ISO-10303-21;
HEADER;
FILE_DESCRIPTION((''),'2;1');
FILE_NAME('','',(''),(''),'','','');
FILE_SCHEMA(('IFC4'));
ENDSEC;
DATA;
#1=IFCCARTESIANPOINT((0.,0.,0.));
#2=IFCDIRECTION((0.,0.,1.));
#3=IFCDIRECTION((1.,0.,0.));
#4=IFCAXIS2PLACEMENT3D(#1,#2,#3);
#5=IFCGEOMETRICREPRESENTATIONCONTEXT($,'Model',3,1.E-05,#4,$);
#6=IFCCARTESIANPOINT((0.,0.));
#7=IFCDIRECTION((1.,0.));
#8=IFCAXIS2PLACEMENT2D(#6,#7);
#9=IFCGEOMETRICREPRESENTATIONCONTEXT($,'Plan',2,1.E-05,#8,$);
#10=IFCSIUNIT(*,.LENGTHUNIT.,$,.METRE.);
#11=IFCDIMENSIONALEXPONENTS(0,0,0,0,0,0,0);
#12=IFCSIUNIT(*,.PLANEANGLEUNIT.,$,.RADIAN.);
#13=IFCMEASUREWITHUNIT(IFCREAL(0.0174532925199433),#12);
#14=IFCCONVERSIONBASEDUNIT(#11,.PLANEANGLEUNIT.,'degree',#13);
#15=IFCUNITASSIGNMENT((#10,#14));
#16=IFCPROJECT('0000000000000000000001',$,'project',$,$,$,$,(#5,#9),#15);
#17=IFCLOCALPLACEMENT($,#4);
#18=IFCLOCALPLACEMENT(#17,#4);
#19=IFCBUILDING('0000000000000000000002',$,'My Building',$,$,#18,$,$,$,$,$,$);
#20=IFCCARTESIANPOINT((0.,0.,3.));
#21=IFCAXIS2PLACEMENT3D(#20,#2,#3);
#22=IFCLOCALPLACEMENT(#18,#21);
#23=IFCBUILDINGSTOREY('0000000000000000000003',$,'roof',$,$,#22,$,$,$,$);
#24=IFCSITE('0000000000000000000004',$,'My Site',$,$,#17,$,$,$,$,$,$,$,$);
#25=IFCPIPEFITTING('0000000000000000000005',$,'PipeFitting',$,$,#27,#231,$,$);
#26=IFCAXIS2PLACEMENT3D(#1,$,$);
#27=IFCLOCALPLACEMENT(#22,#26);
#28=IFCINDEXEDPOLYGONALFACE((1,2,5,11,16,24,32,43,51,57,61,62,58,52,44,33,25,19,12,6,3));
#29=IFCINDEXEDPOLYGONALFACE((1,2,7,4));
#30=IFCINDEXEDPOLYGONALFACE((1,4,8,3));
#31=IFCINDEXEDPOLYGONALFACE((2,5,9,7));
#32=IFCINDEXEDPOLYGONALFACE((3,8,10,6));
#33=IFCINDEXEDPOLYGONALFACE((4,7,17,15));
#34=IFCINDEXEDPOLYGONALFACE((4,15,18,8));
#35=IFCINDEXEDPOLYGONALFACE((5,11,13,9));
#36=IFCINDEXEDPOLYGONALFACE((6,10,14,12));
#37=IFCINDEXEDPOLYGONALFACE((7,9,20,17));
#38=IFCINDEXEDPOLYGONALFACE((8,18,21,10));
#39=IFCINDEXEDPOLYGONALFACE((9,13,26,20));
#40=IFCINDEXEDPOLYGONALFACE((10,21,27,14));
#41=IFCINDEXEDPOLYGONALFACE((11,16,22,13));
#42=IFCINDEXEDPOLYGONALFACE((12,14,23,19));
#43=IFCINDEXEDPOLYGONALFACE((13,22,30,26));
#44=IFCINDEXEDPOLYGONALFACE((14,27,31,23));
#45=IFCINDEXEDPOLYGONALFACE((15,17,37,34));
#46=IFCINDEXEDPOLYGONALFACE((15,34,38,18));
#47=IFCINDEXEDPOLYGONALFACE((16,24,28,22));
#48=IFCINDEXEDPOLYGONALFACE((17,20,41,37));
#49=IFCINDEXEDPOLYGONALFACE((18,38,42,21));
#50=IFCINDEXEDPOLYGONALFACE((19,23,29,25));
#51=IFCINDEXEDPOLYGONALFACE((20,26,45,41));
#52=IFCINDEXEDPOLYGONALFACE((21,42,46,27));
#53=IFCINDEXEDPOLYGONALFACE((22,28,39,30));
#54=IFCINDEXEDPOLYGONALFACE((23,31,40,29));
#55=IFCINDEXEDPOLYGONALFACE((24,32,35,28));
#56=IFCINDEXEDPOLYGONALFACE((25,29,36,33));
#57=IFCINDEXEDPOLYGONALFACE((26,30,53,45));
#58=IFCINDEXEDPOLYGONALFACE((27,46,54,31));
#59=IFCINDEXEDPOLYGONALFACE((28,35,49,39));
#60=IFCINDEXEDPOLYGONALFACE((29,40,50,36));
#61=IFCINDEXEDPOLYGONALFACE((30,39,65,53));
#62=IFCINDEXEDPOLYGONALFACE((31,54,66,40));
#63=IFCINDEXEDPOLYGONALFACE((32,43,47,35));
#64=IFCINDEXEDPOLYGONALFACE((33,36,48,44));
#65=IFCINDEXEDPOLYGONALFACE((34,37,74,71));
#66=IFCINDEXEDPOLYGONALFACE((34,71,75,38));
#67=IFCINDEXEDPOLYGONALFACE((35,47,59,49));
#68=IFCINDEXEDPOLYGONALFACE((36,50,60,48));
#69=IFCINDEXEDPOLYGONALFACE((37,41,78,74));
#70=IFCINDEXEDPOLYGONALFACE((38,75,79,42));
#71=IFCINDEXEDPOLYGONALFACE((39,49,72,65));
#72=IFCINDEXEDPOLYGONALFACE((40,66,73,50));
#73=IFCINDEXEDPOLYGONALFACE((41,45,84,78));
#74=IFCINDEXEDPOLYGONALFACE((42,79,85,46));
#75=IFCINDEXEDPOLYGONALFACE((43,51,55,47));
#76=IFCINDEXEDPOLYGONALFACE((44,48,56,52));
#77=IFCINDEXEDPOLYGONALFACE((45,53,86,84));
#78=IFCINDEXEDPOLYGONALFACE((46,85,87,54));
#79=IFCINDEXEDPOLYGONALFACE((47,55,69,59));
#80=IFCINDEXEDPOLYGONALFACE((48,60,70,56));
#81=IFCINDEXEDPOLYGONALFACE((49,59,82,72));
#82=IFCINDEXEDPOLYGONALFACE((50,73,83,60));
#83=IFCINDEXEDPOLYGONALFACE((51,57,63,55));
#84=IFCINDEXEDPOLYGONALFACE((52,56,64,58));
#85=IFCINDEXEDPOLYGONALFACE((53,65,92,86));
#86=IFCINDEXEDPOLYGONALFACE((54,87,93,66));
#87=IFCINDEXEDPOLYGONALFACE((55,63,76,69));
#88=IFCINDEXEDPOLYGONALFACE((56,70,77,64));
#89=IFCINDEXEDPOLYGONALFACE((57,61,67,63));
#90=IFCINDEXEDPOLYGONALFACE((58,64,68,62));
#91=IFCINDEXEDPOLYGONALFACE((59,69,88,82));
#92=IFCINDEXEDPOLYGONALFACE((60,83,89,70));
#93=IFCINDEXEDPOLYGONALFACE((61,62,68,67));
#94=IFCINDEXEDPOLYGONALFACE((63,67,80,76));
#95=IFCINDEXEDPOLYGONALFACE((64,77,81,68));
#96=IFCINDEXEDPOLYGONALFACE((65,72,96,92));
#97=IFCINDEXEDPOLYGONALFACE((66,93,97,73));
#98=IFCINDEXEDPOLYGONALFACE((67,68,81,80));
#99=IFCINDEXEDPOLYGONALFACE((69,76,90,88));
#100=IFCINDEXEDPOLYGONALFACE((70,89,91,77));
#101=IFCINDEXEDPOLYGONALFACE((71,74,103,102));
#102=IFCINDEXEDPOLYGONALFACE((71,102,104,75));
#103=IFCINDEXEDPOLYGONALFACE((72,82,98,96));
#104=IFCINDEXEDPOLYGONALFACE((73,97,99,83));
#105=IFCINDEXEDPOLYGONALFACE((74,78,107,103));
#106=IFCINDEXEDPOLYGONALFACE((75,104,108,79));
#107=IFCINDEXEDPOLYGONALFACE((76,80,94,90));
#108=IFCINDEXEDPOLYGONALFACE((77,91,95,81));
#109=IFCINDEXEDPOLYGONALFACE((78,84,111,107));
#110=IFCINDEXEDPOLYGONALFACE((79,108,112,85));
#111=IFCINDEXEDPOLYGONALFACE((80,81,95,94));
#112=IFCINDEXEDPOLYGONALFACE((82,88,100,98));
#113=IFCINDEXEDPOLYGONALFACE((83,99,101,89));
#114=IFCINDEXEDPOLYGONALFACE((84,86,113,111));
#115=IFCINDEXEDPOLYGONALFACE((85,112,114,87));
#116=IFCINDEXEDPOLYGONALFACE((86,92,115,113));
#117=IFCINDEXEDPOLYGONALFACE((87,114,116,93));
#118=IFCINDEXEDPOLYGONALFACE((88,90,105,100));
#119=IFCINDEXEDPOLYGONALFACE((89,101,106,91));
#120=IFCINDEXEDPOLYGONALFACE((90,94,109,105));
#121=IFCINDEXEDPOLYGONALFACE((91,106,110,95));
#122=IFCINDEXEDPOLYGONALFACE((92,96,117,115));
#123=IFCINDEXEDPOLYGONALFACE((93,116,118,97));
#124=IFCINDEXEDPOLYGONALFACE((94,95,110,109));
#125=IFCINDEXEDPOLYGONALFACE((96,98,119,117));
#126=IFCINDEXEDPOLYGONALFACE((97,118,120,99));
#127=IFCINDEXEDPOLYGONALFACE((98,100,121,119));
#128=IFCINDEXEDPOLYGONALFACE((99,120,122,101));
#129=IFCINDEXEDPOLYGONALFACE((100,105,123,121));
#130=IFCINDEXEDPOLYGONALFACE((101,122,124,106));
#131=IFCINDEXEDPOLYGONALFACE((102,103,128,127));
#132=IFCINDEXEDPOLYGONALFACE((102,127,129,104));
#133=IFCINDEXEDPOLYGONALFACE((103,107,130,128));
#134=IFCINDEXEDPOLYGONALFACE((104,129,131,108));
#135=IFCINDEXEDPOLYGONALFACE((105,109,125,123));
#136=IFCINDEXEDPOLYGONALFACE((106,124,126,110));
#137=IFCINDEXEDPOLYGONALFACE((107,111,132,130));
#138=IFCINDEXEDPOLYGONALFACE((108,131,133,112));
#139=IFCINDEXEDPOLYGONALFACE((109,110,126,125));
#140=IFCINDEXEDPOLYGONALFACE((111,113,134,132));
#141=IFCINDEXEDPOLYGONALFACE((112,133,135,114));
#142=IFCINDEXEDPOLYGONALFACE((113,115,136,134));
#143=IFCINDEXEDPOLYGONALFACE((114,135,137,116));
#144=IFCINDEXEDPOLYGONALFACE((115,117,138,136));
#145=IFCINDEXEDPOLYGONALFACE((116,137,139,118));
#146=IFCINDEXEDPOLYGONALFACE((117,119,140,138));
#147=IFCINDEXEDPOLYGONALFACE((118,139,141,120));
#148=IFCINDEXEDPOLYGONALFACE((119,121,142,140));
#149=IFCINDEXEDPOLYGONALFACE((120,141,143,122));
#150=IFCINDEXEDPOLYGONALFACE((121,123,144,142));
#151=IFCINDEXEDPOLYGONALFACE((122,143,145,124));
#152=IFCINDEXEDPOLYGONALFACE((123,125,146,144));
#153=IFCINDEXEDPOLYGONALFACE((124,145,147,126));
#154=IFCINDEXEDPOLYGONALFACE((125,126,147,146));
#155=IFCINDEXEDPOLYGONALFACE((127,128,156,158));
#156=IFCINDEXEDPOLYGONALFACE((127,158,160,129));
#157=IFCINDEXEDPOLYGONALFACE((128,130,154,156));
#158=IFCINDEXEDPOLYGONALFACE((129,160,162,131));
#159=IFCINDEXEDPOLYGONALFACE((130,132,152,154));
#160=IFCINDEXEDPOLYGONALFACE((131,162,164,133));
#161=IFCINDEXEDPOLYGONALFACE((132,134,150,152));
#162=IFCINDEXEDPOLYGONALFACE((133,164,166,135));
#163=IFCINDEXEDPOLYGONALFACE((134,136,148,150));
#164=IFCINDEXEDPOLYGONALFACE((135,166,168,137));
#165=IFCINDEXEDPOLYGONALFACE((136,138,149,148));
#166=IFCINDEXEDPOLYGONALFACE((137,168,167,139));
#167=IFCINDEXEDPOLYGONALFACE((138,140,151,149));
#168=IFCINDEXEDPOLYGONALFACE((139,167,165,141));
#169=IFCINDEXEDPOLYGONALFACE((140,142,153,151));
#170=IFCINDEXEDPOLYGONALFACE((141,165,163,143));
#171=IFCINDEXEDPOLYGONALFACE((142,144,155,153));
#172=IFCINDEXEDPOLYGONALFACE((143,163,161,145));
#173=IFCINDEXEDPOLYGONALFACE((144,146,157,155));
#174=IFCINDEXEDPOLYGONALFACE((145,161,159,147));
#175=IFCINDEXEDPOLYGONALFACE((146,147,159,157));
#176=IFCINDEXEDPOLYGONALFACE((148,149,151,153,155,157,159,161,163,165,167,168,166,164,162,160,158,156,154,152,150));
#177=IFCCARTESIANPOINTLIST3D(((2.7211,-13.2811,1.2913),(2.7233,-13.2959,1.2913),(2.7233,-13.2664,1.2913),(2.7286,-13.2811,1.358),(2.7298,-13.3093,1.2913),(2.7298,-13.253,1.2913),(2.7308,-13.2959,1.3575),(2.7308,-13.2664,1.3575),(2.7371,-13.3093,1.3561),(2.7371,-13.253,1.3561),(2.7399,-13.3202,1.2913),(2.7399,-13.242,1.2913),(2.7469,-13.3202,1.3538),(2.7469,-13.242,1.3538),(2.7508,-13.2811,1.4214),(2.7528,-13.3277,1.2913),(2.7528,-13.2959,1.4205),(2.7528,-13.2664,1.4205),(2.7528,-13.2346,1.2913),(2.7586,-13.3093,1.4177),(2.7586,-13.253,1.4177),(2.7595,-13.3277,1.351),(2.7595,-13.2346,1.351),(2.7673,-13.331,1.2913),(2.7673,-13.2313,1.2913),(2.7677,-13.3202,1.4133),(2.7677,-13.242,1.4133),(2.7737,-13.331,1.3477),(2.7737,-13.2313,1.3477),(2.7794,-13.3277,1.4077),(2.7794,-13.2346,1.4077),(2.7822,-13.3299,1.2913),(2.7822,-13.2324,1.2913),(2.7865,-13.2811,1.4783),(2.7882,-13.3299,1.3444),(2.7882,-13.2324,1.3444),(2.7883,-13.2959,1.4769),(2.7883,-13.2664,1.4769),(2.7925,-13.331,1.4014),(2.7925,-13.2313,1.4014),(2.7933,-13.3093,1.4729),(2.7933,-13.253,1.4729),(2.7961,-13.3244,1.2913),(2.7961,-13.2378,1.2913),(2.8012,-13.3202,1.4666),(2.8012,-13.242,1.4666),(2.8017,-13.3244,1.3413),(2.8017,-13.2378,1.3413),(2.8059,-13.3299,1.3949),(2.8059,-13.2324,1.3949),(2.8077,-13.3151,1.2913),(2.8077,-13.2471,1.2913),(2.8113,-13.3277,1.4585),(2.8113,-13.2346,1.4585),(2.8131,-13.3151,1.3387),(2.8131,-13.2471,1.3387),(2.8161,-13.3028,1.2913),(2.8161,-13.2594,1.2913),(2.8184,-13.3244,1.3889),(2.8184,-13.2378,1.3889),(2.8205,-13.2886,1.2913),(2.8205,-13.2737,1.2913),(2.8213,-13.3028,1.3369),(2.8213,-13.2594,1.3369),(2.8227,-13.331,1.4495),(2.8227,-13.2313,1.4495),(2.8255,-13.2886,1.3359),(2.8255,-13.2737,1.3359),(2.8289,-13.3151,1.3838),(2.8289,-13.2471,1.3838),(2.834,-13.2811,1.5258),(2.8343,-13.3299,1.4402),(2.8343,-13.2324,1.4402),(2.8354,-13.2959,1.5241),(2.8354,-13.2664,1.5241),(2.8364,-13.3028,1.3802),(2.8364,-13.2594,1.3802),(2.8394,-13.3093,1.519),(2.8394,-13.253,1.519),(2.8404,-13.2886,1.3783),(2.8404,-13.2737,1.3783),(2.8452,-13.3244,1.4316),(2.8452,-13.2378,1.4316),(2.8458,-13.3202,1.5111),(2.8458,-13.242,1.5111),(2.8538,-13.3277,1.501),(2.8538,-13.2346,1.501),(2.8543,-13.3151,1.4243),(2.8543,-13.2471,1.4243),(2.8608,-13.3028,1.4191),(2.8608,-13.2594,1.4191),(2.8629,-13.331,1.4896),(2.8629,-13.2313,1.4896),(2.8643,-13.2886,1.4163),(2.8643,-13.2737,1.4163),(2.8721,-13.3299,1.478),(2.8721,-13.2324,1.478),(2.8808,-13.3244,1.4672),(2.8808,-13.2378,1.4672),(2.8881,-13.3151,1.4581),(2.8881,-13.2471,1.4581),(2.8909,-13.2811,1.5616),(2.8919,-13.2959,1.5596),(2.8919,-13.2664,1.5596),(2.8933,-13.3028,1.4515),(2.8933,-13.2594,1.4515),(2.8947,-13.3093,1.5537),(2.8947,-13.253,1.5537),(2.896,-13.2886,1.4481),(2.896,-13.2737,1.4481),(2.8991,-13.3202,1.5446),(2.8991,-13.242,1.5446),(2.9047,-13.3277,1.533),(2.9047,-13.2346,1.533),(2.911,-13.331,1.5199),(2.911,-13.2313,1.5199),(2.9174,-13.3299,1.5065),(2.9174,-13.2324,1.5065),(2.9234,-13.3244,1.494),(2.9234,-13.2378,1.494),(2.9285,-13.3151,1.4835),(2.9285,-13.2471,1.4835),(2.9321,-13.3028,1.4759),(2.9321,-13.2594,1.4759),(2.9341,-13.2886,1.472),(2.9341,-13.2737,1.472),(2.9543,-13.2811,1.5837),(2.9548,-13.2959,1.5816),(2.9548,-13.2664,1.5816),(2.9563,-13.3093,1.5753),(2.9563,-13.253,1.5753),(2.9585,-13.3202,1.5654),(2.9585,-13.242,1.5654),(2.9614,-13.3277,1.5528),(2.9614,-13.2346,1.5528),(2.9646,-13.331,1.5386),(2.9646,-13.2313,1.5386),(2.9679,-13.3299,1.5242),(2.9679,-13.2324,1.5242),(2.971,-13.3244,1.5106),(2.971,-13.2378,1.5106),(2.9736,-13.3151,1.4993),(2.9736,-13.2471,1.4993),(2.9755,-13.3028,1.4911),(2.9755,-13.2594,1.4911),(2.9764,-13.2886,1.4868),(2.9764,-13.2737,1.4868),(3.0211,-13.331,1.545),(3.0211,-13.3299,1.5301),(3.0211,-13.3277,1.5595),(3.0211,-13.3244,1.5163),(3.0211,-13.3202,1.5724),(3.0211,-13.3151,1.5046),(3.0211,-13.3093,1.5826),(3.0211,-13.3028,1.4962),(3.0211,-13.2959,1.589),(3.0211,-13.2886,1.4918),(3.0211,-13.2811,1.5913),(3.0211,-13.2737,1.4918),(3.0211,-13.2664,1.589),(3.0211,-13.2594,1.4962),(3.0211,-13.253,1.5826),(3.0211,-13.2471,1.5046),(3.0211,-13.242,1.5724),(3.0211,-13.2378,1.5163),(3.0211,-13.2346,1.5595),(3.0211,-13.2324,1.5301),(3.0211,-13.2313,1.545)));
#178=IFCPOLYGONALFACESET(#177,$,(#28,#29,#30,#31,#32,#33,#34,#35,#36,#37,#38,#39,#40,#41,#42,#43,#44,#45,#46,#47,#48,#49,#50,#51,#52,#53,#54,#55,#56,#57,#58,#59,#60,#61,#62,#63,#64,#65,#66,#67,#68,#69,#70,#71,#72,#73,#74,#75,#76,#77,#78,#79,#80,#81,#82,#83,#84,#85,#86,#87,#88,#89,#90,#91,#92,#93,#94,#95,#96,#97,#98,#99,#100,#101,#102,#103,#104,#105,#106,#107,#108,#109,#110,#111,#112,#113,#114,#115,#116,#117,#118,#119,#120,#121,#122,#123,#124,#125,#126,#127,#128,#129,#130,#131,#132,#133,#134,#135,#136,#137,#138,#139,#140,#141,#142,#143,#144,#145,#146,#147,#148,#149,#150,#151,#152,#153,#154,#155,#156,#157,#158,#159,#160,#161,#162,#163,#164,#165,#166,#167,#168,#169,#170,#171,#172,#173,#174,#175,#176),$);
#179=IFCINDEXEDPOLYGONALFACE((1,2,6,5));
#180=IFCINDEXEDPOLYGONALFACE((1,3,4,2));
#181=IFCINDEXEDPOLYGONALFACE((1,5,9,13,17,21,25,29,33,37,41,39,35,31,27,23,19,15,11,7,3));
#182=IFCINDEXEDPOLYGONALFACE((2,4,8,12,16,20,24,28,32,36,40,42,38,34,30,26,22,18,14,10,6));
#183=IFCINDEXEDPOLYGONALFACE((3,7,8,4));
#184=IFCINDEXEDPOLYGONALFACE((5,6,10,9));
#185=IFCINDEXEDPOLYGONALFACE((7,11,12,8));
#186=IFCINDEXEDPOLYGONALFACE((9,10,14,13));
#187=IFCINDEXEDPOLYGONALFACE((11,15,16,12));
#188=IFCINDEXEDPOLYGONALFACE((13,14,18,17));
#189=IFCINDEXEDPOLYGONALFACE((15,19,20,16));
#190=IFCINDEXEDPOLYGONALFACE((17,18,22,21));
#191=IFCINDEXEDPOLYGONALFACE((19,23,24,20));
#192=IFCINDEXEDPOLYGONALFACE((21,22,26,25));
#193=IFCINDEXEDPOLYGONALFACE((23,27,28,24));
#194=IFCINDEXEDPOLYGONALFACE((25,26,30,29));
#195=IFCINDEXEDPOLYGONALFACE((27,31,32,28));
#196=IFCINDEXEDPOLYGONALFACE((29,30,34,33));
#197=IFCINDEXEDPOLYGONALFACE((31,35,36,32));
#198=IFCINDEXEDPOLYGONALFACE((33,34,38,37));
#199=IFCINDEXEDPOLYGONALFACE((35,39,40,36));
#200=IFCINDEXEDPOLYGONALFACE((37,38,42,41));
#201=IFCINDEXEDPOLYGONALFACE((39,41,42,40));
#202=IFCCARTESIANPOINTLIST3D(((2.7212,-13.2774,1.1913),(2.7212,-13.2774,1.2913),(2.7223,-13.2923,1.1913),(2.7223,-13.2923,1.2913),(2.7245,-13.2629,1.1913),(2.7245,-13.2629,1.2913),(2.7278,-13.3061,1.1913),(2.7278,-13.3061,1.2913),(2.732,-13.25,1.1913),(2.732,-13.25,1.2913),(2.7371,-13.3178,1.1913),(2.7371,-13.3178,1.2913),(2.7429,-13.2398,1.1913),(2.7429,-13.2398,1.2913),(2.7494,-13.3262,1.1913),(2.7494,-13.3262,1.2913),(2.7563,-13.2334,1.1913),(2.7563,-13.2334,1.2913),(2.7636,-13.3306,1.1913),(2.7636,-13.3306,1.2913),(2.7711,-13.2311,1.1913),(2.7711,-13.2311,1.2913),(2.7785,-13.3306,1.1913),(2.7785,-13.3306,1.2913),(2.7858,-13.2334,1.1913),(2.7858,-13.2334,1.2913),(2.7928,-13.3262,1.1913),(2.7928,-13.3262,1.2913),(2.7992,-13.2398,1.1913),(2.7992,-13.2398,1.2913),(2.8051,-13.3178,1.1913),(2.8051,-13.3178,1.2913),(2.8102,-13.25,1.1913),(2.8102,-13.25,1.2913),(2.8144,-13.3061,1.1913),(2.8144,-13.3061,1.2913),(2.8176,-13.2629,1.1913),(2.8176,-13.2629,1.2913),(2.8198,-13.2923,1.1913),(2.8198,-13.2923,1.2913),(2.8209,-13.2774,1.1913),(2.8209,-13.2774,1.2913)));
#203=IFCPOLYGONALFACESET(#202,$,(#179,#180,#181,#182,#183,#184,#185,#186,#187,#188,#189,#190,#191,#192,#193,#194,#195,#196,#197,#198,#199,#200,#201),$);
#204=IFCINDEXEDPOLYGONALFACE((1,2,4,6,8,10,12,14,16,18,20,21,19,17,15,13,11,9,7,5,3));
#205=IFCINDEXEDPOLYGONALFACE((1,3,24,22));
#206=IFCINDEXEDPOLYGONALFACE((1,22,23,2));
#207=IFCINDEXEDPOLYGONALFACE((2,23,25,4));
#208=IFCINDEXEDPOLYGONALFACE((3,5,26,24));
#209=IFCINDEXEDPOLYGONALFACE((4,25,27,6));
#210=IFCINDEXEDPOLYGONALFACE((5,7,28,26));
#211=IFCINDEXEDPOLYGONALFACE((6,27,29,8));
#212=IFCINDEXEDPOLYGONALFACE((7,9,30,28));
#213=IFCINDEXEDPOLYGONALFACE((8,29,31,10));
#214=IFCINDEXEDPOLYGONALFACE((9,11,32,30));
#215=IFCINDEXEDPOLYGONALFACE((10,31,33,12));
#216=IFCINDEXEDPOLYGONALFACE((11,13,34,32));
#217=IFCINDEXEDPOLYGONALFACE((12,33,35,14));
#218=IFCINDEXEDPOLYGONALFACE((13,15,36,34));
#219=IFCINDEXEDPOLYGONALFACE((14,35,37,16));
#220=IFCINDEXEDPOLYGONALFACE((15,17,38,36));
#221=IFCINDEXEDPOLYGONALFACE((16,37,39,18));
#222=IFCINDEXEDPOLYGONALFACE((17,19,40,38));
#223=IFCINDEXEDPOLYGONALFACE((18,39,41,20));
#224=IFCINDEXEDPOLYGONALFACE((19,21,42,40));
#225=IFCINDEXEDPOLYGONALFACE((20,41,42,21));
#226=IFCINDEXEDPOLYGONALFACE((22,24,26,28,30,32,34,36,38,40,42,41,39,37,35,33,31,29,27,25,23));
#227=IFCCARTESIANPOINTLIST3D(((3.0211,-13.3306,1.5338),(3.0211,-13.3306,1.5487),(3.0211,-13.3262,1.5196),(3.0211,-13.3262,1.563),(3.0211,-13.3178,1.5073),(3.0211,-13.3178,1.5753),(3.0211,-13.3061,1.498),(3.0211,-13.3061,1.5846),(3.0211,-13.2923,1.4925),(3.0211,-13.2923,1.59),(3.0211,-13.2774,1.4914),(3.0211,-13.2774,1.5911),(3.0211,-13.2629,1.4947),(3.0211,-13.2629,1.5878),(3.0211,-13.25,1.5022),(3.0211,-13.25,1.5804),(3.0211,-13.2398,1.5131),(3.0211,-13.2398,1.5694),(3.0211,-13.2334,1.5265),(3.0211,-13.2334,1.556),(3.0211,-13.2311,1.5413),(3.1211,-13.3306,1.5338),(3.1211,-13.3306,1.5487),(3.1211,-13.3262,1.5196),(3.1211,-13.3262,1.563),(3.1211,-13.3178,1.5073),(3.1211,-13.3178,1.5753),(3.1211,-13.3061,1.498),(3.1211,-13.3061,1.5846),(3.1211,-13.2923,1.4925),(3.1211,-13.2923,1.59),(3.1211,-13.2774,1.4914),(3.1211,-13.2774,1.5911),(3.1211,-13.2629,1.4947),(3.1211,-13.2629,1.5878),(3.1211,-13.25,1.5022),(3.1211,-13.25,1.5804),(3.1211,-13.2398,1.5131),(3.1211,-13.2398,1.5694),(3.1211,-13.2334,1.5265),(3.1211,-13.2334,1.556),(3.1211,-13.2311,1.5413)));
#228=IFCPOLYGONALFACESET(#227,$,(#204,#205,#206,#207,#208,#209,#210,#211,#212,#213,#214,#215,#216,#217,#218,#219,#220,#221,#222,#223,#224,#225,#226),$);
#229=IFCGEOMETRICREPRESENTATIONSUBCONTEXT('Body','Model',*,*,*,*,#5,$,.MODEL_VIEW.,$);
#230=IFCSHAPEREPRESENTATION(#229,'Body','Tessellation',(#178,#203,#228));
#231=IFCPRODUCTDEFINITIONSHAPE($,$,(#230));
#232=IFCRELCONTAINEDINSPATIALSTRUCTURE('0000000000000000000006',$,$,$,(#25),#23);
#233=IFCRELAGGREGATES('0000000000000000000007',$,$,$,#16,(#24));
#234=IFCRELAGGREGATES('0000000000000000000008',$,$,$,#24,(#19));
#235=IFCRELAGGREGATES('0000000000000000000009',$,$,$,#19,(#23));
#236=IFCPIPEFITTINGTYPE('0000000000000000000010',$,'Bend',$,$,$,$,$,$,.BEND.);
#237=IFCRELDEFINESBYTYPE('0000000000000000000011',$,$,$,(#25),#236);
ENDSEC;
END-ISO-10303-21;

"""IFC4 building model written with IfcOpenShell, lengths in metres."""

from ifc_helpers import new_model, entity, si_unit, converted_unit, frame, origin_with_axes, origin_2d_with_axis, place, context, subcontext, project, spatial, circle, extrude, source, transform, mapped, type_object, type_shapes, element, save


model = new_model("IFC4")

# Units and contexts
model_context = context("Model", 3, precision=1e-05, world=origin_with_axes())
plan_context = context("Plan", 2, precision=1e-05, world=origin_2d_with_axis())
body_context_1 = subcontext(model_context, "Body", "Model", "MODEL_VIEW")
ifc_project = project(units=[si_unit("LENGTHUNIT", "METRE"), converted_unit("PLANEANGLEUNIT", "degree", entity("IfcReal", 0.0174532925199433), si_unit("PLANEANGLEUNIT", "RADIAN"), dimensions=[0, 0, 0, 0, 0, 0, 0])], contexts=[model_context, plan_context])

# Site, building, storey
site_placement = place(None, origin_with_axes())
site = spatial("IfcSite", under=ifc_project, at=site_placement, Name="My Site")
building_placement = place(site_placement, origin_with_axes())
building = spatial("IfcBuilding", under=site, at=building_placement, Name="My Building")
storey_placement = place(building_placement, frame((0.0, 0.0, 3.0), z_axis=(0.0, 0.0, 1.0), x_axis=(1.0, 0.0, 0.0)))
storey = spatial("IfcBuildingStorey", under=building, at=storey_placement, Name="roof")

# Pipe fitting
pipe_fitting_type_1 = type_object("IfcPipeFittingType", Name="Bend", PredefinedType="BEND")
shared_shape_1 = source(origin_with_axes(), body_context_1, "Body", "SolidModel", [
    entity("IfcSweptDiskSolid", entity("IfcIndexedPolyCurve", entity("IfcCartesianPointList3D", [[0.0, 0.0, 0.1], [0.0, -0.0732, 0.2768], [0.0, -0.25, 0.35]]), [entity("IfcArcIndex", [1, 2, 3])]), 0.05),
    extrude(circle(Radius=0.05), origin_with_axes(), (0.0, 0.0, 1.0), 0.1),
    extrude(circle(Radius=0.05), frame((0.0, -0.25, 0.35), z_axis=(0.0, -1.0, 0.0), x_axis=(1.0, 0.0, 0.0)), (0.0, 0.0, 1.0), 0.1),
])
type_shapes(pipe_fitting_type_1, [shared_shape_1])
for number, where, z_axis, x_axis, name in (
    (1, (2.7711, -13.2811, 1.1913), (-0.000001, 0.000001, 1.0), (0.0, 1.0, -0.000001), "PipeFitting"),
):
    element("IfcPipeFitting", number, at=place(storey_placement, frame(where, z_axis=z_axis, x_axis=x_axis)), inside=storey, type_object=pipe_fitting_type_1, Name=name, context=body_context_1, shape_type="MappedRepresentation", body=[
        mapped(shared_shape_1, transform((0.0, 0.0, 0.0), x_axis=(1.0, 0.0, 0.0), y_axis=(0.0, 1.0, 0.0), z_axis=(0.0, 0.0, 1.0), scale=1.0)),
    ])

save(model, "model.ifc")
